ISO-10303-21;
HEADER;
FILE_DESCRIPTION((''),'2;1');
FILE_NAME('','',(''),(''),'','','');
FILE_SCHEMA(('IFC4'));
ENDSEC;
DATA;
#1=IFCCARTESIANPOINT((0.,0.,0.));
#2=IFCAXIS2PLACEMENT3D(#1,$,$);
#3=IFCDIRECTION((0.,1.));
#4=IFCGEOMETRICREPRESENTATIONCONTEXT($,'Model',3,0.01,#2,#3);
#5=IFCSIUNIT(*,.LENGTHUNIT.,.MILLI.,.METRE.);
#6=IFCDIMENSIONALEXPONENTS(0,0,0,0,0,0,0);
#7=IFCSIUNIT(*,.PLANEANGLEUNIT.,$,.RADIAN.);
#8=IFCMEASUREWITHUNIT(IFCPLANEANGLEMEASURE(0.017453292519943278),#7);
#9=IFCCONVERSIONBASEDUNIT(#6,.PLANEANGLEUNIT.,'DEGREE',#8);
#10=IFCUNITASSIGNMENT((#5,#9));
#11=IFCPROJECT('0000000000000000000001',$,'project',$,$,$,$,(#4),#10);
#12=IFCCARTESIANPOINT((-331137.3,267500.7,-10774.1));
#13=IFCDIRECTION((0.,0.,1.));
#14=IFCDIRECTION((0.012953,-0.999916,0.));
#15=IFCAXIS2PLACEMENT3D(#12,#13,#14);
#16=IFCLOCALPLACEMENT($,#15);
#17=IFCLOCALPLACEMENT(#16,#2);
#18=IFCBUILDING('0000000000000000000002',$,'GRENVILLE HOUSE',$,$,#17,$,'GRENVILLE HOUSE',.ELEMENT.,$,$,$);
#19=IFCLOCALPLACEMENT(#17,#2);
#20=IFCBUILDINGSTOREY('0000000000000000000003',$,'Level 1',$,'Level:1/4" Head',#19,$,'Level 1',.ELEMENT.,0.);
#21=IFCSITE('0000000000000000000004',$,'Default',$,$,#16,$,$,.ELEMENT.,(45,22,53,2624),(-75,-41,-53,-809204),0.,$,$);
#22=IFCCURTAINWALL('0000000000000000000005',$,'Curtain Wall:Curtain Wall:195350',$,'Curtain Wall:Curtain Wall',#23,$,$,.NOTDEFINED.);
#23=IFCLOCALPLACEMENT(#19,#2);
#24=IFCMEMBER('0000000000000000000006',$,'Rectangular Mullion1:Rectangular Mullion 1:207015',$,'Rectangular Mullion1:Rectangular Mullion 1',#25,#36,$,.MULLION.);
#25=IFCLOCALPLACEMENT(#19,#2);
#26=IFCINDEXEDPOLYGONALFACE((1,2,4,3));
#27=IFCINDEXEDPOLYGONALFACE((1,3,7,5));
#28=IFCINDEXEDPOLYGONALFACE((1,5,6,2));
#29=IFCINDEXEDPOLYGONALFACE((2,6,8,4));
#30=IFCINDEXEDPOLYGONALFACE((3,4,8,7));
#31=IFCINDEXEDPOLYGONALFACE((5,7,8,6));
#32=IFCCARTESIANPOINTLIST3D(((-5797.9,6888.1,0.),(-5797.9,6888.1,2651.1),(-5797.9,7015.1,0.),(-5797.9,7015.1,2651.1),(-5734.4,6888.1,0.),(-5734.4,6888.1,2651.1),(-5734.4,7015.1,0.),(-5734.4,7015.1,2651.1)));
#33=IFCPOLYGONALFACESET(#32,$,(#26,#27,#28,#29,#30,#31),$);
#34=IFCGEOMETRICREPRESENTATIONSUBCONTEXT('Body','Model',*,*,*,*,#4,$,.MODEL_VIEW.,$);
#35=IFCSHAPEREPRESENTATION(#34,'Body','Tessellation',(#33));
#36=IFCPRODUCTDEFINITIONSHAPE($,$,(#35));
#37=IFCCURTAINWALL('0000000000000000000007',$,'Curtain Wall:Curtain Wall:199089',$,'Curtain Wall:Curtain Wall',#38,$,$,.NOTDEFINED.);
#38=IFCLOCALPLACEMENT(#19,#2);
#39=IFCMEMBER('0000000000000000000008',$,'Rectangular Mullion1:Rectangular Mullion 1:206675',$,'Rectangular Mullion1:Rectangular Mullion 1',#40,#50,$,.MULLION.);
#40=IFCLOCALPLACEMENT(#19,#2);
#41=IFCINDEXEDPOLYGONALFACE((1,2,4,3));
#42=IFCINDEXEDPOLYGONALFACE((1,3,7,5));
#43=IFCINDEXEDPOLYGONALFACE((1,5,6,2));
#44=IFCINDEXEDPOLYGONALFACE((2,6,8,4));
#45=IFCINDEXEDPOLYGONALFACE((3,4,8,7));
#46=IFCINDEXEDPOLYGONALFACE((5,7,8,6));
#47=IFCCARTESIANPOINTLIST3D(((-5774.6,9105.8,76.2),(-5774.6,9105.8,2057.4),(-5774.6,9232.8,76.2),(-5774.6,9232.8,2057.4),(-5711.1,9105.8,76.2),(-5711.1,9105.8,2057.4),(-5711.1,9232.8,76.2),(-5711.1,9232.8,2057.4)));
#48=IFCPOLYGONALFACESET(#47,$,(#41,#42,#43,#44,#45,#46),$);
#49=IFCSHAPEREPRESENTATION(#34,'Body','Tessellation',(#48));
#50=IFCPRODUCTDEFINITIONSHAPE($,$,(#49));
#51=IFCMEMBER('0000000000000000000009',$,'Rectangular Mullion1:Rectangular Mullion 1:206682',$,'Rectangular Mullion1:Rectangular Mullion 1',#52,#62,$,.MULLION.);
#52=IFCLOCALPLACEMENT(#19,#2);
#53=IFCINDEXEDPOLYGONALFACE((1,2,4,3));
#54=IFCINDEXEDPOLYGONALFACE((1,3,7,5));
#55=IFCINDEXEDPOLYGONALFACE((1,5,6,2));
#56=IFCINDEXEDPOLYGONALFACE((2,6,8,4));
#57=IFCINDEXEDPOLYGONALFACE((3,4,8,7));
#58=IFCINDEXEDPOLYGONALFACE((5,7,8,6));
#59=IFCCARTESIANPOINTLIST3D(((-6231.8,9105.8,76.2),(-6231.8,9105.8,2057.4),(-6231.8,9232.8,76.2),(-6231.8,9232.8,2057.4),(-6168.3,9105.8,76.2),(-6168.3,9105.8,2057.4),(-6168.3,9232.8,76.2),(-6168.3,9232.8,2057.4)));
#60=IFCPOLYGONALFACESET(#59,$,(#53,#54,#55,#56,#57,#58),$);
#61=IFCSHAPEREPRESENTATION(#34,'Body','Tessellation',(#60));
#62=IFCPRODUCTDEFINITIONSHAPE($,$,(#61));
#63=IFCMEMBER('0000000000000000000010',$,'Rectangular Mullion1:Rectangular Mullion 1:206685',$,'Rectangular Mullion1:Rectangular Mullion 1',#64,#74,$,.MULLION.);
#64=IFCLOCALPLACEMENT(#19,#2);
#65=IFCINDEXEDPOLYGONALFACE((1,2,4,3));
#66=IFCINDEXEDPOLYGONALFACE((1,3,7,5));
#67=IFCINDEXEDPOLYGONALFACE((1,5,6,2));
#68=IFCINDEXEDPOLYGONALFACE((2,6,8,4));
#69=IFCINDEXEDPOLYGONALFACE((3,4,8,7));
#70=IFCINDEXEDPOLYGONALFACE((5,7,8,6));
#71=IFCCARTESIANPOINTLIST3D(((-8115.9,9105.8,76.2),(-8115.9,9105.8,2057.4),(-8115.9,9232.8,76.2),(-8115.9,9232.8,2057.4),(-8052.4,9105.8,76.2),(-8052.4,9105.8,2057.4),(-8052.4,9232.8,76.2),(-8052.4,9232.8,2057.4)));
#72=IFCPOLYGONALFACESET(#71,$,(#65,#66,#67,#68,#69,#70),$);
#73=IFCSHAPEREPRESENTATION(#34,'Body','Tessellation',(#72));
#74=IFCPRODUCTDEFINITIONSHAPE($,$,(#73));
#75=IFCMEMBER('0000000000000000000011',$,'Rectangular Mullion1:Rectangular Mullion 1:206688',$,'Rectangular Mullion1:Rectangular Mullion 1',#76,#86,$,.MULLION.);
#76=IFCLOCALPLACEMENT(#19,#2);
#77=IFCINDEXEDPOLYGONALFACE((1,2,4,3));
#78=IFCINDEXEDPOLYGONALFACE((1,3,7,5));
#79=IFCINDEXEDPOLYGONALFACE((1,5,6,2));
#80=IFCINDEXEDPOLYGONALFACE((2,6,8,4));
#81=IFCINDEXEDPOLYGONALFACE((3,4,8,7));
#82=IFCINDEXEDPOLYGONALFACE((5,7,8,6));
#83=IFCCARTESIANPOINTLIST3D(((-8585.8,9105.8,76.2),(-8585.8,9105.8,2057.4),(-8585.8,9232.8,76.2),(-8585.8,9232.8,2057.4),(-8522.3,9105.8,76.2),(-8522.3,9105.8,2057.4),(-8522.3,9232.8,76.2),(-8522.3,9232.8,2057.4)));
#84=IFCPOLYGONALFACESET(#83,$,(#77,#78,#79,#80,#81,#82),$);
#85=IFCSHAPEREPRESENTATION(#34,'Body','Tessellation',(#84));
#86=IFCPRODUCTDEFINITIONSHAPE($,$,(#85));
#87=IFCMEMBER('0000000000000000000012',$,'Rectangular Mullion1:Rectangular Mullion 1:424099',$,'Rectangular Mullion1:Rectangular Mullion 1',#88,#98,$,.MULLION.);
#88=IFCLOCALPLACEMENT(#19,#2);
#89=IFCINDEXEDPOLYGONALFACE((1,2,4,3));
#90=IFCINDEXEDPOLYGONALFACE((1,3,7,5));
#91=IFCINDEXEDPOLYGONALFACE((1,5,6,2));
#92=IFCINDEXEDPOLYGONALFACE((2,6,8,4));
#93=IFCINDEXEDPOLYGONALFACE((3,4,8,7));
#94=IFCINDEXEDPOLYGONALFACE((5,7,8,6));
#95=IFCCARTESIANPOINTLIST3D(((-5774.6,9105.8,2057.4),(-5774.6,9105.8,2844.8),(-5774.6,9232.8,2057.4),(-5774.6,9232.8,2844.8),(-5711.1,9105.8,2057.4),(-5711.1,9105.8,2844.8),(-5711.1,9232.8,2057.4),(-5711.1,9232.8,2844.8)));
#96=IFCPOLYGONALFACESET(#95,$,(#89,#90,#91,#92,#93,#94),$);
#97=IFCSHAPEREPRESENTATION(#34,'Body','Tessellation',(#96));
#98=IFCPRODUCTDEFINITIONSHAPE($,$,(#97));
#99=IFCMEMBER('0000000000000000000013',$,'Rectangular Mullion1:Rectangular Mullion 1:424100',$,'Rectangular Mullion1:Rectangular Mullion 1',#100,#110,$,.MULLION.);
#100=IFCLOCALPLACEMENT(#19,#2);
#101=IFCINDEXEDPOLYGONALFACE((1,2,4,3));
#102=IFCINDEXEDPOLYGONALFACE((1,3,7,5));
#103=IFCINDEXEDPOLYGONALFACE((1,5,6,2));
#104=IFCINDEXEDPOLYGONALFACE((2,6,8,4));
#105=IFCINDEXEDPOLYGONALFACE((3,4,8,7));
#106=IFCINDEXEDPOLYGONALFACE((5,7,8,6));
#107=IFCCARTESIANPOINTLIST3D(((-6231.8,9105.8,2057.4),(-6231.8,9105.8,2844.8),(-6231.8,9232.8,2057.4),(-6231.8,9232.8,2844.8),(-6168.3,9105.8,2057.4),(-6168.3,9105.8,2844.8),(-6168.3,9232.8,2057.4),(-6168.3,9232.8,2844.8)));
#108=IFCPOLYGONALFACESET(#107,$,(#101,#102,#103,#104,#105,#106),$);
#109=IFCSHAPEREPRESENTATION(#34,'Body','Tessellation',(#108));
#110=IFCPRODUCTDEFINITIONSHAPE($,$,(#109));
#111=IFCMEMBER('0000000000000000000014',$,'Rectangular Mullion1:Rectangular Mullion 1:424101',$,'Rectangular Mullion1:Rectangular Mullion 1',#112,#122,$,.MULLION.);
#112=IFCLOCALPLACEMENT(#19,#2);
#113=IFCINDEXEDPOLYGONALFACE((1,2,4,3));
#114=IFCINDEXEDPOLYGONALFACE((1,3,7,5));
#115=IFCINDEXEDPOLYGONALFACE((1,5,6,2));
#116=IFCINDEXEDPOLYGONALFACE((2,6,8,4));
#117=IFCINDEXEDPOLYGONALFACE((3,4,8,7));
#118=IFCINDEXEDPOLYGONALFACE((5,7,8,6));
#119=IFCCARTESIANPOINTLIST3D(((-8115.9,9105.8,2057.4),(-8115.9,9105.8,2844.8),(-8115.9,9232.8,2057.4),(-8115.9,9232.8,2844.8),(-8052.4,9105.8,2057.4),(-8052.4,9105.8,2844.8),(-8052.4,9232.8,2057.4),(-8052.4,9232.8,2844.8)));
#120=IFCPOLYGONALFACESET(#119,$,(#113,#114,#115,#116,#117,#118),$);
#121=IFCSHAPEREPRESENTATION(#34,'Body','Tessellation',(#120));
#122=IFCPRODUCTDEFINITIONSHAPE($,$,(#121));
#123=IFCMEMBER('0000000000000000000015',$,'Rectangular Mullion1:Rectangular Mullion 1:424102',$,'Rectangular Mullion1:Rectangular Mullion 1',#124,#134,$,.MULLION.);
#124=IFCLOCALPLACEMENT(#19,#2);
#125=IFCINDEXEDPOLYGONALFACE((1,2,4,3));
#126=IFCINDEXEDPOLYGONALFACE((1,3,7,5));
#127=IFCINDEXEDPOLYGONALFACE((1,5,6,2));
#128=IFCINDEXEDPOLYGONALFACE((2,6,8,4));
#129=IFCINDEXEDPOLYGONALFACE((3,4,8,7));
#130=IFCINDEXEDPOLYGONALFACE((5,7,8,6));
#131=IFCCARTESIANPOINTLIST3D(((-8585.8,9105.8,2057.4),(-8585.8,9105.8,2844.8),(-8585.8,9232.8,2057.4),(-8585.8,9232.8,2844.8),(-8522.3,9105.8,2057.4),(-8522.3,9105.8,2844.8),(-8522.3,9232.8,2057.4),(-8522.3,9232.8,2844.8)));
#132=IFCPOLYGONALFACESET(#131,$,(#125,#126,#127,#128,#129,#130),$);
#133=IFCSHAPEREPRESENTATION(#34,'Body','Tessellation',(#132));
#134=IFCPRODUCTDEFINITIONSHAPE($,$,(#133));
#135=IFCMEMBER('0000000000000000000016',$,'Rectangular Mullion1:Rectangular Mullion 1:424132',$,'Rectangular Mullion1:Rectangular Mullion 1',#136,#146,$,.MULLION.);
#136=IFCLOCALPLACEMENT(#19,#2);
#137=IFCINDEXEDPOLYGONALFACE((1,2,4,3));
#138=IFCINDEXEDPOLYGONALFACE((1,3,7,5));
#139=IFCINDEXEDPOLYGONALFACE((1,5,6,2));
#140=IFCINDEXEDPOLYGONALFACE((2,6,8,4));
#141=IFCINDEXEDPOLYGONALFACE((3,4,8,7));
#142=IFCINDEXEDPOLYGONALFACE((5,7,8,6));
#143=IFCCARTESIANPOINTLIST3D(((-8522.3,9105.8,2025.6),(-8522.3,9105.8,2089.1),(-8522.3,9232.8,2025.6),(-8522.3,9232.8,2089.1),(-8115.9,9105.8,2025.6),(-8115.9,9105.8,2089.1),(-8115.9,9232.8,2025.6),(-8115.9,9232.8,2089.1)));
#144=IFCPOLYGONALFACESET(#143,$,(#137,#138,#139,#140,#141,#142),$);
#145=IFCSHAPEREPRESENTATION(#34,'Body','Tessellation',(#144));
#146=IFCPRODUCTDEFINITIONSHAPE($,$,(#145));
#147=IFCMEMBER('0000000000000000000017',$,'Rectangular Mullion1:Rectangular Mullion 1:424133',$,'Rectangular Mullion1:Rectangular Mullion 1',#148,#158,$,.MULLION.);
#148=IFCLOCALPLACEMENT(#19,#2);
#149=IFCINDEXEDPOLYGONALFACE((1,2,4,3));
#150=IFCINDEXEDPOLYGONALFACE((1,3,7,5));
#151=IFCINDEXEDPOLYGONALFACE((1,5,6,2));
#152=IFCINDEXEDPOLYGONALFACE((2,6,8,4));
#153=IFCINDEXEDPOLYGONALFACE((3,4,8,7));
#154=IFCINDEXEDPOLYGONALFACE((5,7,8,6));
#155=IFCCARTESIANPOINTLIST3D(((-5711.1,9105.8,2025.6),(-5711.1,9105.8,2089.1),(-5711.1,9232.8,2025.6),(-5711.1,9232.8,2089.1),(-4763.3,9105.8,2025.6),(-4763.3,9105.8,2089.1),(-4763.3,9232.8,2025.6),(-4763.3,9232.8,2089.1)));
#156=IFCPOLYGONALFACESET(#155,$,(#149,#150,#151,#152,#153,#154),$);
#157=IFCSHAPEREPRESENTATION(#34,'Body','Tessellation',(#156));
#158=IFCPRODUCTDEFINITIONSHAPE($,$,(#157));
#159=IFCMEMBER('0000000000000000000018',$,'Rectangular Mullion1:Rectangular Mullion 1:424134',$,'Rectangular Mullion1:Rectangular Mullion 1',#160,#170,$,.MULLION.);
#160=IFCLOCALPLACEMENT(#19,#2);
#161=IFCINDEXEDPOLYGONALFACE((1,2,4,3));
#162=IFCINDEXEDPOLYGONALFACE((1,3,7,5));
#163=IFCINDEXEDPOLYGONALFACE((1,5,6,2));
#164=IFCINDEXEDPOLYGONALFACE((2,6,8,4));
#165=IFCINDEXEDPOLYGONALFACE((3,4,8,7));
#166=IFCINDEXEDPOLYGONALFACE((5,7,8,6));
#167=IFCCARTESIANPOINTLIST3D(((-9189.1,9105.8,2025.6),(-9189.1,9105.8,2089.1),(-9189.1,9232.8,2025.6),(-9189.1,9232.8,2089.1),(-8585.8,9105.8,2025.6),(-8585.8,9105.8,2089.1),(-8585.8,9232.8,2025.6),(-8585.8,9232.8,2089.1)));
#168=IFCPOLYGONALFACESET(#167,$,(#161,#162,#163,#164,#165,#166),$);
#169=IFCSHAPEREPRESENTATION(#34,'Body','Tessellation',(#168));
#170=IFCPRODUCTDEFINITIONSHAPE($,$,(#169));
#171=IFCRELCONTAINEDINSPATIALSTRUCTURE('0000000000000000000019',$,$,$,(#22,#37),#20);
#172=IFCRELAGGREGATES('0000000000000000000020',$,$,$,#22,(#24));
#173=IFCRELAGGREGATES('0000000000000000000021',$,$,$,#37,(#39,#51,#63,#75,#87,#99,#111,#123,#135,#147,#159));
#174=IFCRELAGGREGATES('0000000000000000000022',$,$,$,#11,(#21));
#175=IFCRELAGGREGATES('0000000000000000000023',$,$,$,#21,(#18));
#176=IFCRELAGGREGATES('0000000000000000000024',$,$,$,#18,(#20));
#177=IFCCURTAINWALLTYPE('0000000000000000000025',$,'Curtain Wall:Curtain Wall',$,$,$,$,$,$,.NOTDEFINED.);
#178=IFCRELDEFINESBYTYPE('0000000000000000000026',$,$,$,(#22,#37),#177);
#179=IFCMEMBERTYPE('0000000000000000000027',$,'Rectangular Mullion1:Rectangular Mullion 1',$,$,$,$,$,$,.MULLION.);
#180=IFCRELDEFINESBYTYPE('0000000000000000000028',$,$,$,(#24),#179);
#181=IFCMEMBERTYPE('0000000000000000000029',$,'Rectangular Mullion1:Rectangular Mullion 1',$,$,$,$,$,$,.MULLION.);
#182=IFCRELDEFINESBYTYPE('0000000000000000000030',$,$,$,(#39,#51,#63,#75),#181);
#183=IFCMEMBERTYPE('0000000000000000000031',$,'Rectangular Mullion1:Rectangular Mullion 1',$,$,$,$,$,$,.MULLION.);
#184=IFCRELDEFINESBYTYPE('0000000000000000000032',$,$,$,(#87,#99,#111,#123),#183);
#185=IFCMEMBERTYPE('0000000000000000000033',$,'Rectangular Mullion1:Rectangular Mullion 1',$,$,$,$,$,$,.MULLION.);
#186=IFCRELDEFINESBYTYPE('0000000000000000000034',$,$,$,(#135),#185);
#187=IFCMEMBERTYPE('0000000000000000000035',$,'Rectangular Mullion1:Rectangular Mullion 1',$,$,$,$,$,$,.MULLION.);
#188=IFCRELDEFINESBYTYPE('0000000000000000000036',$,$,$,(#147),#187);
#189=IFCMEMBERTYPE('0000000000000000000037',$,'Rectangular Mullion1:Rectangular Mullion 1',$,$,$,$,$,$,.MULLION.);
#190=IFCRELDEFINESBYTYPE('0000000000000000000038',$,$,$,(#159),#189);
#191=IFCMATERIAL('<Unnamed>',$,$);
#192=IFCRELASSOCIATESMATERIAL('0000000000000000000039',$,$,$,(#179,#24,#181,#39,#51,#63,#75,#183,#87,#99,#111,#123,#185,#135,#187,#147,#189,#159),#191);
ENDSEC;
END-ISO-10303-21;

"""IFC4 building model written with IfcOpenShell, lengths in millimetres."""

from ifc_helpers import new_model, entity, si_unit, converted_unit, direction, frame, origin, place, context, subcontext, project, spatial, indexed_curve, outline, extrude, source, transform, mapped, material, type_object, type_shapes, element, aggregate, save


model = new_model("IFC4")

# Units and contexts
model_context = context("Model", 3, precision=0.01, world=origin(), true_north=direction((0.0, 1.0)))
body_context = subcontext(model_context, "Body", "Model", "MODEL_VIEW")
ifc_project = project(units=[si_unit("LENGTHUNIT", "METRE", prefix="MILLI"), converted_unit("PLANEANGLEUNIT", "DEGREE", entity("IfcPlaneAngleMeasure", 0.017453292519943278), si_unit("PLANEANGLEUNIT", "RADIAN"), dimensions=[0, 0, 0, 0, 0, 0, 0])], contexts=[model_context])

# Site, building, storey
site_placement = place(None, frame((-331137.3, 267500.7, -10774.1), z_axis=(0.0, 0.0, 1.0), x_axis=(0.012953, -0.999916, 0.0)))
site = spatial("IfcSite", under=ifc_project, at=site_placement, Name="Default", CompositionType="ELEMENT", RefLatitude=(45, 22, 53, 2624), RefLongitude=(-75, -41, -53, -809204), RefElevation=0.0)
building_placement = place(site_placement, origin())
building = spatial("IfcBuilding", under=site, at=building_placement, Name="GRENVILLE HOUSE", LongName="GRENVILLE HOUSE", CompositionType="ELEMENT")
storey_placement = place(building_placement, origin())
storey = spatial("IfcBuildingStorey", under=building, at=storey_placement, Name="Level 1", ObjectType="Level:1/4\" Head", LongName="Level 1", CompositionType="ELEMENT", Elevation=0.0)

# Curtain wall, member
curtain_wall_type = type_object("IfcCurtainWallType", Name="Curtain Wall:Curtain Wall", PredefinedType="NOTDEFINED")
curtain_wall_1_placement = place(storey_placement, origin())
curtain_wall_1 = element("IfcCurtainWall", 1, at=curtain_wall_1_placement, inside=storey, type_object=curtain_wall_type, Name="Curtain Wall:Curtain Wall:195350", ObjectType="Curtain Wall:Curtain Wall", PredefinedType="NOTDEFINED")
ifc_material_1 = material(Name="<Unnamed>")
member_type_1 = type_object("IfcMemberType", Name="Rectangular Mullion1:Rectangular Mullion 1", PredefinedType="MULLION", material=ifc_material_1)
shared_shape_1 = source(origin(), body_context, "Body", "SweptSolid", [
    extrude(outline(indexed_curve([(-31.8, -63.5), (31.8, -63.5), (31.8, 63.5), (-31.8, 63.5), (-31.8, -63.5)], self_intersect=False)), frame((0.0, 0.0, -2651.1), z_axis=(0.0, 0.0, 1.0), x_axis=(-1.0, 0.0, 0.0)), (0.0, 0.0, 1.0), 2651.1),
])
type_shapes(member_type_1, [shared_shape_1])
member_1_placement = place(curtain_wall_1_placement, frame((-5766.1, 6951.6, 0.0), z_axis=(0.0, 0.0, -1.0), x_axis=(-1.0, 0.0, 0.0)))
member_1 = element("IfcMember", 2, at=member_1_placement, type_object=member_type_1, material=ifc_material_1, Name="Rectangular Mullion1:Rectangular Mullion 1:207015", ObjectType="Rectangular Mullion1:Rectangular Mullion 1", PredefinedType="MULLION", context=body_context, shape_type="MappedRepresentation", body=[
    mapped(shared_shape_1, transform((0.0, 0.0, 0.0), scale=1.0)),
])
aggregate(curtain_wall_1, [member_1])

# Curtain wall, members
curtain_wall_2_placement = place(storey_placement, origin())
curtain_wall_2 = element("IfcCurtainWall", 3, at=curtain_wall_2_placement, inside=storey, type_object=curtain_wall_type, Name="Curtain Wall:Curtain Wall:199089", ObjectType="Curtain Wall:Curtain Wall", PredefinedType="NOTDEFINED")
member_type_2 = type_object("IfcMemberType", Name="Rectangular Mullion1:Rectangular Mullion 1", PredefinedType="MULLION", material=ifc_material_1)
shared_shape_2 = source(origin(), body_context, "Body", "SweptSolid", [
    extrude(outline(indexed_curve([(-31.8, -63.5), (31.8, -63.5), (31.8, 63.5), (-31.8, 63.5), (-31.8, -63.5)], self_intersect=False)), frame((0.0, 0.0, -1981.2), z_axis=(0.0, 0.0, 1.0), x_axis=(-1.0, 0.0, 0.0)), (0.0, 0.0, 1.0), 1981.2),
])
type_shapes(member_type_2, [shared_shape_2])
member_2_placement = place(curtain_wall_2_placement, frame((-5742.8, 9169.3, 76.2), z_axis=(0.0, 0.0, -1.0), x_axis=(1.0, 0.0, 0.0)))
member_2 = element("IfcMember", 4, at=member_2_placement, type_object=member_type_2, material=ifc_material_1, Name="Rectangular Mullion1:Rectangular Mullion 1:206675", ObjectType="Rectangular Mullion1:Rectangular Mullion 1", PredefinedType="MULLION", context=body_context, shape_type="MappedRepresentation", body=[
    mapped(shared_shape_2, transform((0.0, 0.0, 0.0), scale=1.0)),
])
member_3_placement = place(curtain_wall_2_placement, frame((-6200.0, 9169.3, 76.2), z_axis=(0.0, 0.0, -1.0), x_axis=(1.0, 0.0, 0.0)))
member_3 = element("IfcMember", 5, at=member_3_placement, type_object=member_type_2, material=ifc_material_1, Name="Rectangular Mullion1:Rectangular Mullion 1:206682", ObjectType="Rectangular Mullion1:Rectangular Mullion 1", PredefinedType="MULLION", context=body_context, shape_type="MappedRepresentation", body=[
    mapped(shared_shape_2, transform((0.0, 0.0, 0.0), scale=1.0)),
])
member_4_placement = place(curtain_wall_2_placement, frame((-8084.2, 9169.3, 76.2), z_axis=(0.0, 0.0, -1.0), x_axis=(1.0, 0.0, 0.0)))
member_4 = element("IfcMember", 6, at=member_4_placement, type_object=member_type_2, material=ifc_material_1, Name="Rectangular Mullion1:Rectangular Mullion 1:206685", ObjectType="Rectangular Mullion1:Rectangular Mullion 1", PredefinedType="MULLION", context=body_context, shape_type="MappedRepresentation", body=[
    mapped(shared_shape_2, transform((0.0, 0.0, 0.0), scale=1.0)),
])
member_5_placement = place(curtain_wall_2_placement, frame((-8554.1, 9169.3, 76.2), z_axis=(0.0, 0.0, -1.0), x_axis=(1.0, 0.0, 0.0)))
member_5 = element("IfcMember", 7, at=member_5_placement, type_object=member_type_2, material=ifc_material_1, Name="Rectangular Mullion1:Rectangular Mullion 1:206688", ObjectType="Rectangular Mullion1:Rectangular Mullion 1", PredefinedType="MULLION", context=body_context, shape_type="MappedRepresentation", body=[
    mapped(shared_shape_2, transform((0.0, 0.0, 0.0), scale=1.0)),
])
member_type_3 = type_object("IfcMemberType", Name="Rectangular Mullion1:Rectangular Mullion 1", PredefinedType="MULLION", material=ifc_material_1)
shared_shape_3 = source(origin(), body_context, "Body", "SweptSolid", [
    extrude(outline(indexed_curve([(-31.8, -63.5), (31.8, -63.5), (31.8, 63.5), (-31.8, 63.5), (-31.8, -63.5)], self_intersect=False)), frame((0.0, 0.0, -787.4), z_axis=(0.0, 0.0, 1.0), x_axis=(-1.0, 0.0, 0.0)), (0.0, 0.0, 1.0), 787.4),
])
type_shapes(member_type_3, [shared_shape_3])
member_6_placement = place(curtain_wall_2_placement, frame((-5742.8, 9169.3, 2057.4), z_axis=(0.0, 0.0, -1.0), x_axis=(1.0, 0.0, 0.0)))
member_6 = element("IfcMember", 8, at=member_6_placement, type_object=member_type_3, material=ifc_material_1, Name="Rectangular Mullion1:Rectangular Mullion 1:424099", ObjectType="Rectangular Mullion1:Rectangular Mullion 1", PredefinedType="MULLION", context=body_context, shape_type="MappedRepresentation", body=[
    mapped(shared_shape_3, transform((0.0, 0.0, 0.0), scale=1.0)),
])
member_7_placement = place(curtain_wall_2_placement, frame((-6200.0, 9169.3, 2057.4), z_axis=(0.0, 0.0, -1.0), x_axis=(1.0, 0.0, 0.0)))
member_7 = element("IfcMember", 9, at=member_7_placement, type_object=member_type_3, material=ifc_material_1, Name="Rectangular Mullion1:Rectangular Mullion 1:424100", ObjectType="Rectangular Mullion1:Rectangular Mullion 1", PredefinedType="MULLION", context=body_context, shape_type="MappedRepresentation", body=[
    mapped(shared_shape_3, transform((0.0, 0.0, 0.0), scale=1.0)),
])
member_8_placement = place(curtain_wall_2_placement, frame((-8084.2, 9169.3, 2057.4), z_axis=(0.0, 0.0, -1.0), x_axis=(1.0, 0.0, 0.0)))
member_8 = element("IfcMember", 10, at=member_8_placement, type_object=member_type_3, material=ifc_material_1, Name="Rectangular Mullion1:Rectangular Mullion 1:424101", ObjectType="Rectangular Mullion1:Rectangular Mullion 1", PredefinedType="MULLION", context=body_context, shape_type="MappedRepresentation", body=[
    mapped(shared_shape_3, transform((0.0, 0.0, 0.0), scale=1.0)),
])
member_9_placement = place(curtain_wall_2_placement, frame((-8554.1, 9169.3, 2057.4), z_axis=(0.0, 0.0, -1.0), x_axis=(1.0, 0.0, 0.0)))
member_9 = element("IfcMember", 11, at=member_9_placement, type_object=member_type_3, material=ifc_material_1, Name="Rectangular Mullion1:Rectangular Mullion 1:424102", ObjectType="Rectangular Mullion1:Rectangular Mullion 1", PredefinedType="MULLION", context=body_context, shape_type="MappedRepresentation", body=[
    mapped(shared_shape_3, transform((0.0, 0.0, 0.0), scale=1.0)),
])
member_type_4 = type_object("IfcMemberType", Name="Rectangular Mullion1:Rectangular Mullion 1", PredefinedType="MULLION", material=ifc_material_1)
shared_shape_4 = source(origin(), body_context, "Body", "SweptSolid", [
    extrude(outline(indexed_curve([(-31.8, -63.5), (31.8, -63.5), (31.8, 63.5), (-31.8, 63.5), (-31.8, -63.5)], self_intersect=False)), frame((0.0, 0.0, -406.4), z_axis=(0.0, 0.0, 1.0), x_axis=(-1.0, 0.0, 0.0)), (0.0, 0.0, 1.0), 406.4),
])
type_shapes(member_type_4, [shared_shape_4])
member_10_placement = place(curtain_wall_2_placement, frame((-8115.9, 9169.3, 2057.4), z_axis=(1.0, 0.0, 0.0), x_axis=(0.0, 0.0, 1.0)))
member_10 = element("IfcMember", 12, at=member_10_placement, type_object=member_type_4, material=ifc_material_1, Name="Rectangular Mullion1:Rectangular Mullion 1:424132", ObjectType="Rectangular Mullion1:Rectangular Mullion 1", PredefinedType="MULLION", context=body_context, shape_type="MappedRepresentation", body=[
    mapped(shared_shape_4, transform((0.0, 0.0, 0.0), scale=1.0)),
])
member_type_5 = type_object("IfcMemberType", Name="Rectangular Mullion1:Rectangular Mullion 1", PredefinedType="MULLION", material=ifc_material_1)
shared_shape_5 = source(origin(), body_context, "Body", "SweptSolid", [
    extrude(outline(indexed_curve([(-31.8, -63.5), (31.8, -63.5), (31.8, 63.5), (-31.8, 63.5), (-31.8, -63.5)], self_intersect=False)), frame((0.0, 0.0, -947.7), z_axis=(0.0, 0.0, 1.0), x_axis=(-1.0, 0.0, 0.0)), (0.0, 0.0, 1.0), 947.7),
])
type_shapes(member_type_5, [shared_shape_5])
member_11_placement = place(curtain_wall_2_placement, frame((-4763.3, 9169.3, 2057.4), z_axis=(1.0, 0.0, 0.0), x_axis=(0.0, 0.0, 1.0)))
member_11 = element("IfcMember", 13, at=member_11_placement, type_object=member_type_5, material=ifc_material_1, Name="Rectangular Mullion1:Rectangular Mullion 1:424133", ObjectType="Rectangular Mullion1:Rectangular Mullion 1", PredefinedType="MULLION", context=body_context, shape_type="MappedRepresentation", body=[
    mapped(shared_shape_5, transform((0.0, 0.0, 0.0), scale=1.0)),
])
member_type_6 = type_object("IfcMemberType", Name="Rectangular Mullion1:Rectangular Mullion 1", PredefinedType="MULLION", material=ifc_material_1)
shared_shape_6 = source(origin(), body_context, "Body", "SweptSolid", [
    extrude(outline(indexed_curve([(-31.8, -63.5), (31.8, -63.5), (31.8, 63.5), (-31.8, 63.5), (-31.8, -63.5)], self_intersect=False)), frame((0.0, 0.0, -603.3), z_axis=(0.0, 0.0, 1.0), x_axis=(-1.0, 0.0, 0.0)), (0.0, 0.0, 1.0), 603.3),
])
type_shapes(member_type_6, [shared_shape_6])
member_12_placement = place(curtain_wall_2_placement, frame((-8585.8, 9169.3, 2057.4), z_axis=(1.0, 0.0, 0.0), x_axis=(0.0, 0.0, 1.0)))
member_12 = element("IfcMember", 14, at=member_12_placement, type_object=member_type_6, material=ifc_material_1, Name="Rectangular Mullion1:Rectangular Mullion 1:424134", ObjectType="Rectangular Mullion1:Rectangular Mullion 1", PredefinedType="MULLION", context=body_context, shape_type="MappedRepresentation", body=[
    mapped(shared_shape_6, transform((0.0, 0.0, 0.0), scale=1.0)),
])

aggregate(curtain_wall_2, [member_2, member_3, member_4, member_5, member_6, member_7, member_8, member_9, member_10, member_11, member_12])

save(model, "model.ifc")
